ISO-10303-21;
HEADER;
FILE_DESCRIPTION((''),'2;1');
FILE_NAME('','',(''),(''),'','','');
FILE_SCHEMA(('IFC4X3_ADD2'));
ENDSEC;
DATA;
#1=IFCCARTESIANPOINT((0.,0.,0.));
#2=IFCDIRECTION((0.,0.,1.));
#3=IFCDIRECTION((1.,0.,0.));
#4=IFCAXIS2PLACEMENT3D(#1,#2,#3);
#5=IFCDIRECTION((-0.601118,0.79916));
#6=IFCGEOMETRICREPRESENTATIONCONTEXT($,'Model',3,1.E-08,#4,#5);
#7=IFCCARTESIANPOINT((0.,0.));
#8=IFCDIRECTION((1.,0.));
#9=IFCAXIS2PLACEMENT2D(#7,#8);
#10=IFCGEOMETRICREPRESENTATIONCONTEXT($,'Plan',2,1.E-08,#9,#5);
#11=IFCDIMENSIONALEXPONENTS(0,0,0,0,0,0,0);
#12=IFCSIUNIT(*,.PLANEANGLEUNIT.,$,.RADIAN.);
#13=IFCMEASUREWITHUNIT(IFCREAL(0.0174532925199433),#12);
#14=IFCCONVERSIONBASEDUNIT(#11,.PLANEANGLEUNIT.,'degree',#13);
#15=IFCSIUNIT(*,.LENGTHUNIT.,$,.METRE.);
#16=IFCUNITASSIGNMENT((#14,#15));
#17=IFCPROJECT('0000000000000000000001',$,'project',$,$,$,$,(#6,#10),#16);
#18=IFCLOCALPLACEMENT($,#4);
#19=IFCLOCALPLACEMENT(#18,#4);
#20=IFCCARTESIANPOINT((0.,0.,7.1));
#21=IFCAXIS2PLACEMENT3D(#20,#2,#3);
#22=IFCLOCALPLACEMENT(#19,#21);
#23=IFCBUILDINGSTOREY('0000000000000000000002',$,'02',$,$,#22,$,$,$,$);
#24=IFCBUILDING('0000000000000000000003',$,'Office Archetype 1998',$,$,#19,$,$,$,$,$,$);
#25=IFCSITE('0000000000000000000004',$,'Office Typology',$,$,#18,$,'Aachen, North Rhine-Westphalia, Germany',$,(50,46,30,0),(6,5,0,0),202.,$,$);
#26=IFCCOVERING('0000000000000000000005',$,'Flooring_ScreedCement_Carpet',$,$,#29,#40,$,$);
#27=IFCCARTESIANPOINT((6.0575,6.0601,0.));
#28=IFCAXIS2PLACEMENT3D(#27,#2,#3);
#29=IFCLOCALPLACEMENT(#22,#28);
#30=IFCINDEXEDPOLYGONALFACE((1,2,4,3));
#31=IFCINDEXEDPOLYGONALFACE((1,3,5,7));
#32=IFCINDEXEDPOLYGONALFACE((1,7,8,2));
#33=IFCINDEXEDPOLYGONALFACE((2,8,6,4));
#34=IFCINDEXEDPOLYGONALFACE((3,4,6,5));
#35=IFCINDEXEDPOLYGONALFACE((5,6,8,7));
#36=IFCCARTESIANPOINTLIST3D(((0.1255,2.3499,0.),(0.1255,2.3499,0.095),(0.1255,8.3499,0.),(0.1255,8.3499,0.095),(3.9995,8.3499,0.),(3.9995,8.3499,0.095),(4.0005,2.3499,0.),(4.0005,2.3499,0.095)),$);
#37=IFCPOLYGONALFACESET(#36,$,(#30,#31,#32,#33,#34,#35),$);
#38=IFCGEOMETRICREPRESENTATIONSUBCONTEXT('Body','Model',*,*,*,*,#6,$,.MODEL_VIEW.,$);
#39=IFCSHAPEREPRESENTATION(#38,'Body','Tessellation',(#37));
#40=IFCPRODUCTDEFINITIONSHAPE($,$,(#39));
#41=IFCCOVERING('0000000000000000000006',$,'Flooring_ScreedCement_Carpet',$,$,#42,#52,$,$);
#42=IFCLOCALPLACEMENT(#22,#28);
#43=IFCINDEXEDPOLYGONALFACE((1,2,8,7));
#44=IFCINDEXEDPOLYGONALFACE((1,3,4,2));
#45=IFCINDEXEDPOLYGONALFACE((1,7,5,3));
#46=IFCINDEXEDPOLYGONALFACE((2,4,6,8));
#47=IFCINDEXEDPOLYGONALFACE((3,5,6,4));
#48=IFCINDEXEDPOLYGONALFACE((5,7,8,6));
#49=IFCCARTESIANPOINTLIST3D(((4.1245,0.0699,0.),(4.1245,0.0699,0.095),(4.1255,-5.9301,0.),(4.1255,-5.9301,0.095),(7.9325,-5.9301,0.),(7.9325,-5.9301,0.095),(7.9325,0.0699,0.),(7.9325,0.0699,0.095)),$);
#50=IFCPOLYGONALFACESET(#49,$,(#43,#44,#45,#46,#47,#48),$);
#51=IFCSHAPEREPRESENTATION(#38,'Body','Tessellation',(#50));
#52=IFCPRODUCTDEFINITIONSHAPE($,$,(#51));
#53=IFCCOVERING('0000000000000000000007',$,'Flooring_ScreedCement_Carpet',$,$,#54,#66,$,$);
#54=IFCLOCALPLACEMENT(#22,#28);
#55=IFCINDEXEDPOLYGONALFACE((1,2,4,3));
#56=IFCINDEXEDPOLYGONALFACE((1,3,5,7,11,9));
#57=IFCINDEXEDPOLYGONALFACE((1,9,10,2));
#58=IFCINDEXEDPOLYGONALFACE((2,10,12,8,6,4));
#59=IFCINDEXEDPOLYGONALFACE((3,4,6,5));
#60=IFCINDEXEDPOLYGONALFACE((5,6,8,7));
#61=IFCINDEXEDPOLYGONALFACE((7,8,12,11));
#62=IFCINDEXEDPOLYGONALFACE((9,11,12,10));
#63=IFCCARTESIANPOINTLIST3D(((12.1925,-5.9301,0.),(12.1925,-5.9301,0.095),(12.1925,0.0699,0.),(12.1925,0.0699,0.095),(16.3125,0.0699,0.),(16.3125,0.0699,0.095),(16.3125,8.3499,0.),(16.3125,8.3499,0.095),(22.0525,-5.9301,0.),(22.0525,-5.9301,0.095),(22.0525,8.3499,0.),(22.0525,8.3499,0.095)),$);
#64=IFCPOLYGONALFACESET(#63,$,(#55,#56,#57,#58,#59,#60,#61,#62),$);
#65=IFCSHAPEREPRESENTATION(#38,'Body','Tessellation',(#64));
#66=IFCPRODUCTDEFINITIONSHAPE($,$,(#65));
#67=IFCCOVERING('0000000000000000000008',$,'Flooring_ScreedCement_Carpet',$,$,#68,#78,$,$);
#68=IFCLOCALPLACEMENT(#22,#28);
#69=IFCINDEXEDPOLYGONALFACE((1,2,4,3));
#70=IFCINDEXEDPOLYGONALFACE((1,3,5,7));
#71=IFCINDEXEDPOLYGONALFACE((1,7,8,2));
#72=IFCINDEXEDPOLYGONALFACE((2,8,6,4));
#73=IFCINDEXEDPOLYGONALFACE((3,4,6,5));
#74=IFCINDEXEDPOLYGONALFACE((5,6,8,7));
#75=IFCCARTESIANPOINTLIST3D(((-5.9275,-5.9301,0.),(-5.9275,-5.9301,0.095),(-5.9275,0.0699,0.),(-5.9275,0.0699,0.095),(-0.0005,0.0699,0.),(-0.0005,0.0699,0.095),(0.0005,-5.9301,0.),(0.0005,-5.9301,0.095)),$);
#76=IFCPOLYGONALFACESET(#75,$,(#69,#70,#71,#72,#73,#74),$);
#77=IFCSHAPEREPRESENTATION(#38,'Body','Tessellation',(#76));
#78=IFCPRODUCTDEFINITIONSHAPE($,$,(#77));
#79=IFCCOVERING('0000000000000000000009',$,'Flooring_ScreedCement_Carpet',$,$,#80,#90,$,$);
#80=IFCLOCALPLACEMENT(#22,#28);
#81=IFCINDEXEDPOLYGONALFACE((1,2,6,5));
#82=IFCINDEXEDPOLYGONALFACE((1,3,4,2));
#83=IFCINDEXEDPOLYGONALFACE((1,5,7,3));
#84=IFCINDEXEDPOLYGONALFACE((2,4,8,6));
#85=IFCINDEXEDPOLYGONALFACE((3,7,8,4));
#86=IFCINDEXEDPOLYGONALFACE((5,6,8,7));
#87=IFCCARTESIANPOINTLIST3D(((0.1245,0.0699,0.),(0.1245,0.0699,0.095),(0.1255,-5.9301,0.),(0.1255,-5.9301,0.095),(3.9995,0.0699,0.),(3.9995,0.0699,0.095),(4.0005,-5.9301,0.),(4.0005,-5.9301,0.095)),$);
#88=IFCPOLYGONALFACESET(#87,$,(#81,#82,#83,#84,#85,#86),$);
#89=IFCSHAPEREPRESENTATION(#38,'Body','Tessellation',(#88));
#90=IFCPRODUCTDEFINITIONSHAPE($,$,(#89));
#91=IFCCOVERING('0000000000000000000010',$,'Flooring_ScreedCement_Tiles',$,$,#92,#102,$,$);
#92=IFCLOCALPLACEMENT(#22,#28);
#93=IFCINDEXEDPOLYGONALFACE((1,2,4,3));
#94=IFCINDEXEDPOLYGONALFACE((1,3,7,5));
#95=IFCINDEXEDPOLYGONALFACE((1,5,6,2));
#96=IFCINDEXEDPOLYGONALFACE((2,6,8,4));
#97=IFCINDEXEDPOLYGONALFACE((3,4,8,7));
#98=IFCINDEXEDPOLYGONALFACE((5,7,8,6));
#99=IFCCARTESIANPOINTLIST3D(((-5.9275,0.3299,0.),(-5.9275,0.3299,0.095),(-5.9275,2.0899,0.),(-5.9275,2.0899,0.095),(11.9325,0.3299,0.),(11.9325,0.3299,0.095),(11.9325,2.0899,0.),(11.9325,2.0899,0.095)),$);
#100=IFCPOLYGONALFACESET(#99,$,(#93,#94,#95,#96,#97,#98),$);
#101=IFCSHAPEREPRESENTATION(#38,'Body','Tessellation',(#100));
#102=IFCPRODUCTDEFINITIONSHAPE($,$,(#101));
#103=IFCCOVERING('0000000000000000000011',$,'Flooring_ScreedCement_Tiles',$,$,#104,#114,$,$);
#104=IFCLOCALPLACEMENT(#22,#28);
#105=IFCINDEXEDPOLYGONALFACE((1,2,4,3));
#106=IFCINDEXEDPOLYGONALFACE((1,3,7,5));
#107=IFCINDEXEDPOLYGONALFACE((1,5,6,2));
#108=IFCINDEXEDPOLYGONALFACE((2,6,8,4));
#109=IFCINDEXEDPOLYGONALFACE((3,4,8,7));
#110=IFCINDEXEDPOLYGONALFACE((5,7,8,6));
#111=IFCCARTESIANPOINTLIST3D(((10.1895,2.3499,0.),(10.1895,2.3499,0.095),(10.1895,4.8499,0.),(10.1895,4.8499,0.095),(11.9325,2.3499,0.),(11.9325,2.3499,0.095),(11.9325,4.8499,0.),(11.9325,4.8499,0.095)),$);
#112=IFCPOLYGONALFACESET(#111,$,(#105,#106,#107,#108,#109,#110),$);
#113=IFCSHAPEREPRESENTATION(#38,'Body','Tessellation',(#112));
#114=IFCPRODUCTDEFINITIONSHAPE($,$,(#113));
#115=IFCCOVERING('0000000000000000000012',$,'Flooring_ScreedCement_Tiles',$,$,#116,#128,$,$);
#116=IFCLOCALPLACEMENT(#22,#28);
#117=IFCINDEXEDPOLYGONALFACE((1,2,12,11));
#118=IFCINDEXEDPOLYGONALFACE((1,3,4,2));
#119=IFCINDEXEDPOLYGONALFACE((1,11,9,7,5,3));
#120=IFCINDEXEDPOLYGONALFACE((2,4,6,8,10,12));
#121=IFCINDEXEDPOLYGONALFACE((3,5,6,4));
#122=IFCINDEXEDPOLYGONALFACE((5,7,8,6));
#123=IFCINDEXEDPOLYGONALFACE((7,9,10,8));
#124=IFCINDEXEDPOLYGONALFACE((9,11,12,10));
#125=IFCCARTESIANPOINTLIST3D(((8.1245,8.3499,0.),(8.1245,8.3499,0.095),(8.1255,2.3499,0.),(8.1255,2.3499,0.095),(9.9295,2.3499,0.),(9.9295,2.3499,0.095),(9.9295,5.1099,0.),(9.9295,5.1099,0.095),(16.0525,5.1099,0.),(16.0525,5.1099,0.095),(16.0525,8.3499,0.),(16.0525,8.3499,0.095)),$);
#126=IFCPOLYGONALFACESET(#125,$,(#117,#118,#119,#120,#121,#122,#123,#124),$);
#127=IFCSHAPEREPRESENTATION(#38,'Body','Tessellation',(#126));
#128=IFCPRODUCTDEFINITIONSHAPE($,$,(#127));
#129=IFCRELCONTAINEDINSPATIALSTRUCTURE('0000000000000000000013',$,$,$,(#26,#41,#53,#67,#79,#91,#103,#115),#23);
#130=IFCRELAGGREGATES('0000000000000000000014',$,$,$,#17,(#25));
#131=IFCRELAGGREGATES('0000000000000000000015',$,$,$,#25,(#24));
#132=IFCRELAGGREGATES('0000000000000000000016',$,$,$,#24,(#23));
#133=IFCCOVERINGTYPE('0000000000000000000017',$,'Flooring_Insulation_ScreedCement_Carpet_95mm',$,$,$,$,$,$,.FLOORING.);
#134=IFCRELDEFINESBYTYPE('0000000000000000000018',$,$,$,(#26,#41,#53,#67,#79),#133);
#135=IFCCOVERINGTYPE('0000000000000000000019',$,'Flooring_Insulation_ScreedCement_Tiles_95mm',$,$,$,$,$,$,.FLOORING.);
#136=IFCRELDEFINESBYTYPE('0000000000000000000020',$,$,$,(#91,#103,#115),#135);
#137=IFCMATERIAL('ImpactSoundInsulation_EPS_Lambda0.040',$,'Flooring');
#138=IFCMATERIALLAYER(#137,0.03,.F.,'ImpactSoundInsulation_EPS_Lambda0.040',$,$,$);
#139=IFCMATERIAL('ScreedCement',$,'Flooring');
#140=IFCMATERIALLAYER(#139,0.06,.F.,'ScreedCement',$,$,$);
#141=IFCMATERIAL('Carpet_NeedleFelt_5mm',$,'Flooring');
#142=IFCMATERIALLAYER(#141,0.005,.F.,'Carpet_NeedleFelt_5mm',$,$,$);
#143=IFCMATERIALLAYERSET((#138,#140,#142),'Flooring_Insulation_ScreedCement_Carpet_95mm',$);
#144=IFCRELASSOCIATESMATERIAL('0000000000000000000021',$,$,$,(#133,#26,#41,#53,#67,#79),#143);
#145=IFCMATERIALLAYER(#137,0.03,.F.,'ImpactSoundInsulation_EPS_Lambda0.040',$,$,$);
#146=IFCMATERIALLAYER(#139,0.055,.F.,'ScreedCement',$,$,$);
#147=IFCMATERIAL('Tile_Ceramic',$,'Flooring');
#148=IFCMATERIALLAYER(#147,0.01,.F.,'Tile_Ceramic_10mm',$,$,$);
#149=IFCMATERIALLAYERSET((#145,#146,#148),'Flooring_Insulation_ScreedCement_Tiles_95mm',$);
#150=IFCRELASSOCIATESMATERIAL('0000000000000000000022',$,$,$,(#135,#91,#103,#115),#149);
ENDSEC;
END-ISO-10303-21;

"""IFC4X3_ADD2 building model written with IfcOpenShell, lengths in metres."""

from ifc_helpers import new_model, entity, si_unit, converted_unit, direction, frame, origin_with_axes, origin_2d_with_axis, place, context, subcontext, project, spatial, line, indexed_curve, outline, extrude, material, layer, layer_set, layer_usage, type_object, element, save


model = new_model("IFC4X3_ADD2")

# Units and contexts
model_context = context("Model", 3, precision=1e-08, world=origin_with_axes(), true_north=direction((-0.601118, 0.79916)))
plan_context = context("Plan", 2, precision=1e-08, world=origin_2d_with_axis(), true_north=direction((-0.601118, 0.79916)))
body_context = subcontext(model_context, "Body", "Model", "MODEL_VIEW")
ifc_project = project(units=[converted_unit("PLANEANGLEUNIT", "degree", entity("IfcReal", 0.0174532925199433), si_unit("PLANEANGLEUNIT", "RADIAN"), dimensions=[0, 0, 0, 0, 0, 0, 0]), si_unit("LENGTHUNIT", "METRE")], contexts=[model_context, plan_context])

# Site, building, storey
site_placement = place(None, origin_with_axes())
site = spatial("IfcSite", under=ifc_project, at=site_placement, Name="Office Typology", LongName="Aachen, North Rhine-Westphalia, Germany", RefLatitude=(50, 46, 30, 0), RefLongitude=(6, 5, 0, 0), RefElevation=202.0)
building_placement = place(site_placement, origin_with_axes())
building = spatial("IfcBuilding", under=site, at=building_placement, Name="Office Archetype 1998")
storey_placement = place(building_placement, frame((0.0, 0.0, 7.1), z_axis=(0.0, 0.0, 1.0), x_axis=(1.0, 0.0, 0.0)))
storey = spatial("IfcBuildingStorey", under=building, at=storey_placement, Name="02")

# Coverings
ifc_material_1 = material(Name="ImpactSoundInsulation_EPS_Lambda0.040", Category="Flooring")
ifc_layer_1 = layer(ifc_material_1, 0.03, ventilated=False, Name="ImpactSoundInsulation_EPS_Lambda0.040")
ifc_material_2 = material(Name="ScreedCement", Category="Flooring")
ifc_layer_2 = layer(ifc_material_2, 0.06, ventilated=False, Name="ScreedCement")
ifc_material_3 = material(Name="Carpet_NeedleFelt_5mm", Category="Flooring")
ifc_layer_3 = layer(ifc_material_3, 0.005, ventilated=False, Name="Carpet_NeedleFelt_5mm")
ifc_layer_set_1 = layer_set([ifc_layer_1, ifc_layer_2, ifc_layer_3], Name="Flooring_Insulation_ScreedCement_Carpet_95mm")
ifc_layer_usage_1 = layer_usage(ifc_layer_set_1, "AXIS3", "POSITIVE", 0.0)
covering_type_1 = type_object("IfcCoveringType", Name="Flooring_Insulation_ScreedCement_Carpet_95mm", PredefinedType="FLOORING", material=ifc_layer_set_1)
covering_1_placement = place(storey_placement, frame((6.0575, 6.0601, 0.0), z_axis=(0.0, 0.0, 1.0), x_axis=(1.0, 0.0, 0.0)))
element("IfcCovering", 1, at=covering_1_placement, inside=storey, type_object=covering_type_1, material=ifc_layer_usage_1, Name="Flooring_ScreedCement_Carpet", context=body_context, shape_type="SweptSolid", body=[
    extrude(outline(indexed_curve([(0.1255, 2.3499), (0.1255, 8.3499), (3.9995, 8.3499), (4.0005, 2.3499)], segments=[line(1, 2, 3, 4, 1)])), origin_with_axes(), (0.0, 0.0, 1.0), 0.095),
])
ifc_layer_usage_2 = layer_usage(ifc_layer_set_1, "AXIS3", "POSITIVE", 0.0)
covering_2_placement = place(storey_placement, frame((6.0575, 6.0601, 0.0), z_axis=(0.0, 0.0, 1.0), x_axis=(1.0, 0.0, 0.0)))
element("IfcCovering", 2, at=covering_2_placement, inside=storey, type_object=covering_type_1, material=ifc_layer_usage_2, Name="Flooring_ScreedCement_Carpet", context=body_context, shape_type="SweptSolid", body=[
    extrude(outline(indexed_curve([(4.1245, 0.0699), (7.9325, 0.0699), (7.9325, -5.9301), (4.1255, -5.9301)], segments=[line(1, 2, 3, 4, 1)])), origin_with_axes(), (0.0, 0.0, 1.0), 0.095),
])
ifc_layer_usage_3 = layer_usage(ifc_layer_set_1, "AXIS3", "POSITIVE", 0.0)
covering_3_placement = place(storey_placement, frame((6.0575, 6.0601, 0.0), z_axis=(0.0, 0.0, 1.0), x_axis=(1.0, 0.0, 0.0)))
element("IfcCovering", 3, at=covering_3_placement, inside=storey, type_object=covering_type_1, material=ifc_layer_usage_3, Name="Flooring_ScreedCement_Carpet", context=body_context, shape_type="SweptSolid", body=[
    extrude(outline(indexed_curve([(16.3125, 8.3499), (22.0525, 8.3499), (22.0525, -5.9301), (12.1925, -5.9301), (12.1925, 0.0699), (16.3125, 0.0699)], segments=[line(1, 2, 3, 4, 5, 6, 1)])), origin_with_axes(), (0.0, 0.0, 1.0), 0.095),
])
ifc_layer_usage_4 = layer_usage(ifc_layer_set_1, "AXIS3", "POSITIVE", 0.0)
covering_4_placement = place(storey_placement, frame((6.0575, 6.0601, 0.0), z_axis=(0.0, 0.0, 1.0), x_axis=(1.0, 0.0, 0.0)))
element("IfcCovering", 4, at=covering_4_placement, inside=storey, type_object=covering_type_1, material=ifc_layer_usage_4, Name="Flooring_ScreedCement_Carpet", context=body_context, shape_type="SweptSolid", body=[
    extrude(outline(indexed_curve([(-5.9275, -5.9301), (-5.9275, 0.0699), (-0.0005, 0.0699), (0.0005, -5.9301)], segments=[line(1, 2, 3, 4, 1)])), origin_with_axes(), (0.0, 0.0, 1.0), 0.095),
])
ifc_layer_usage_5 = layer_usage(ifc_layer_set_1, "AXIS3", "POSITIVE", 0.0)
covering_5_placement = place(storey_placement, frame((6.0575, 6.0601, 0.0), z_axis=(0.0, 0.0, 1.0), x_axis=(1.0, 0.0, 0.0)))
element("IfcCovering", 5, at=covering_5_placement, inside=storey, type_object=covering_type_1, material=ifc_layer_usage_5, Name="Flooring_ScreedCement_Carpet", context=body_context, shape_type="SweptSolid", body=[
    extrude(outline(indexed_curve([(0.1255, -5.9301), (0.1245, 0.0699), (3.9995, 0.0699), (4.0005, -5.9301)], segments=[line(1, 2, 3, 4, 1)])), origin_with_axes(), (0.0, 0.0, 1.0), 0.095),
])
ifc_layer_4 = layer(ifc_material_1, 0.03, ventilated=False, Name="ImpactSoundInsulation_EPS_Lambda0.040")
ifc_layer_5 = layer(ifc_material_2, 0.055, ventilated=False, Name="ScreedCement")
ifc_material_4 = material(Name="Tile_Ceramic", Category="Flooring")
ifc_layer_6 = layer(ifc_material_4, 0.01, ventilated=False, Name="Tile_Ceramic_10mm")
ifc_layer_set_2 = layer_set([ifc_layer_4, ifc_layer_5, ifc_layer_6], Name="Flooring_Insulation_ScreedCement_Tiles_95mm")
ifc_layer_usage_6 = layer_usage(ifc_layer_set_2, "AXIS3", "POSITIVE", 0.0)
covering_type_2 = type_object("IfcCoveringType", Name="Flooring_Insulation_ScreedCement_Tiles_95mm", PredefinedType="FLOORING", material=ifc_layer_set_2)
covering_6_placement = place(storey_placement, frame((6.0575, 6.0601, 0.0), z_axis=(0.0, 0.0, 1.0), x_axis=(1.0, 0.0, 0.0)))
element("IfcCovering", 6, at=covering_6_placement, inside=storey, type_object=covering_type_2, material=ifc_layer_usage_6, Name="Flooring_ScreedCement_Tiles", context=body_context, shape_type="SweptSolid", body=[
    extrude(outline(indexed_curve([(-5.9275, 0.3299), (-5.9275, 2.0899), (11.9325, 2.0899), (11.9325, 0.3299)], segments=[line(1, 2, 3, 4, 1)])), None, (0.0, 0.0, 1.0), 0.095),
])
ifc_layer_usage_7 = layer_usage(ifc_layer_set_2, "AXIS3", "POSITIVE", 0.0)
covering_7_placement = place(storey_placement, frame((6.0575, 6.0601, 0.0), z_axis=(0.0, 0.0, 1.0), x_axis=(1.0, 0.0, 0.0)))
element("IfcCovering", 7, at=covering_7_placement, inside=storey, type_object=covering_type_2, material=ifc_layer_usage_7, Name="Flooring_ScreedCement_Tiles", context=body_context, shape_type="SweptSolid", body=[
    extrude(outline(indexed_curve([(11.9325, 4.8499), (11.9325, 2.3499), (10.1895, 2.3499), (10.1895, 4.8499)], segments=[line(1, 2, 3, 4, 1)])), None, (0.0, 0.0, 1.0), 0.095),
])
ifc_layer_usage_8 = layer_usage(ifc_layer_set_2, "AXIS3", "POSITIVE", 0.0)
covering_8_placement = place(storey_placement, frame((6.0575, 6.0601, 0.0), z_axis=(0.0, 0.0, 1.0), x_axis=(1.0, 0.0, 0.0)))
element("IfcCovering", 8, at=covering_8_placement, inside=storey, type_object=covering_type_2, material=ifc_layer_usage_8, Name="Flooring_ScreedCement_Tiles", context=body_context, shape_type="SweptSolid", body=[
    extrude(outline(indexed_curve([(9.9295, 2.3499), (8.1255, 2.3499), (8.1245, 8.3499), (16.0525, 8.3499), (16.0525, 5.1099), (9.9295, 5.1099)], segments=[line(1, 2, 3, 4, 5, 6, 1)])), None, (0.0, 0.0, 1.0), 0.095),
])

save(model, "model.ifc")
